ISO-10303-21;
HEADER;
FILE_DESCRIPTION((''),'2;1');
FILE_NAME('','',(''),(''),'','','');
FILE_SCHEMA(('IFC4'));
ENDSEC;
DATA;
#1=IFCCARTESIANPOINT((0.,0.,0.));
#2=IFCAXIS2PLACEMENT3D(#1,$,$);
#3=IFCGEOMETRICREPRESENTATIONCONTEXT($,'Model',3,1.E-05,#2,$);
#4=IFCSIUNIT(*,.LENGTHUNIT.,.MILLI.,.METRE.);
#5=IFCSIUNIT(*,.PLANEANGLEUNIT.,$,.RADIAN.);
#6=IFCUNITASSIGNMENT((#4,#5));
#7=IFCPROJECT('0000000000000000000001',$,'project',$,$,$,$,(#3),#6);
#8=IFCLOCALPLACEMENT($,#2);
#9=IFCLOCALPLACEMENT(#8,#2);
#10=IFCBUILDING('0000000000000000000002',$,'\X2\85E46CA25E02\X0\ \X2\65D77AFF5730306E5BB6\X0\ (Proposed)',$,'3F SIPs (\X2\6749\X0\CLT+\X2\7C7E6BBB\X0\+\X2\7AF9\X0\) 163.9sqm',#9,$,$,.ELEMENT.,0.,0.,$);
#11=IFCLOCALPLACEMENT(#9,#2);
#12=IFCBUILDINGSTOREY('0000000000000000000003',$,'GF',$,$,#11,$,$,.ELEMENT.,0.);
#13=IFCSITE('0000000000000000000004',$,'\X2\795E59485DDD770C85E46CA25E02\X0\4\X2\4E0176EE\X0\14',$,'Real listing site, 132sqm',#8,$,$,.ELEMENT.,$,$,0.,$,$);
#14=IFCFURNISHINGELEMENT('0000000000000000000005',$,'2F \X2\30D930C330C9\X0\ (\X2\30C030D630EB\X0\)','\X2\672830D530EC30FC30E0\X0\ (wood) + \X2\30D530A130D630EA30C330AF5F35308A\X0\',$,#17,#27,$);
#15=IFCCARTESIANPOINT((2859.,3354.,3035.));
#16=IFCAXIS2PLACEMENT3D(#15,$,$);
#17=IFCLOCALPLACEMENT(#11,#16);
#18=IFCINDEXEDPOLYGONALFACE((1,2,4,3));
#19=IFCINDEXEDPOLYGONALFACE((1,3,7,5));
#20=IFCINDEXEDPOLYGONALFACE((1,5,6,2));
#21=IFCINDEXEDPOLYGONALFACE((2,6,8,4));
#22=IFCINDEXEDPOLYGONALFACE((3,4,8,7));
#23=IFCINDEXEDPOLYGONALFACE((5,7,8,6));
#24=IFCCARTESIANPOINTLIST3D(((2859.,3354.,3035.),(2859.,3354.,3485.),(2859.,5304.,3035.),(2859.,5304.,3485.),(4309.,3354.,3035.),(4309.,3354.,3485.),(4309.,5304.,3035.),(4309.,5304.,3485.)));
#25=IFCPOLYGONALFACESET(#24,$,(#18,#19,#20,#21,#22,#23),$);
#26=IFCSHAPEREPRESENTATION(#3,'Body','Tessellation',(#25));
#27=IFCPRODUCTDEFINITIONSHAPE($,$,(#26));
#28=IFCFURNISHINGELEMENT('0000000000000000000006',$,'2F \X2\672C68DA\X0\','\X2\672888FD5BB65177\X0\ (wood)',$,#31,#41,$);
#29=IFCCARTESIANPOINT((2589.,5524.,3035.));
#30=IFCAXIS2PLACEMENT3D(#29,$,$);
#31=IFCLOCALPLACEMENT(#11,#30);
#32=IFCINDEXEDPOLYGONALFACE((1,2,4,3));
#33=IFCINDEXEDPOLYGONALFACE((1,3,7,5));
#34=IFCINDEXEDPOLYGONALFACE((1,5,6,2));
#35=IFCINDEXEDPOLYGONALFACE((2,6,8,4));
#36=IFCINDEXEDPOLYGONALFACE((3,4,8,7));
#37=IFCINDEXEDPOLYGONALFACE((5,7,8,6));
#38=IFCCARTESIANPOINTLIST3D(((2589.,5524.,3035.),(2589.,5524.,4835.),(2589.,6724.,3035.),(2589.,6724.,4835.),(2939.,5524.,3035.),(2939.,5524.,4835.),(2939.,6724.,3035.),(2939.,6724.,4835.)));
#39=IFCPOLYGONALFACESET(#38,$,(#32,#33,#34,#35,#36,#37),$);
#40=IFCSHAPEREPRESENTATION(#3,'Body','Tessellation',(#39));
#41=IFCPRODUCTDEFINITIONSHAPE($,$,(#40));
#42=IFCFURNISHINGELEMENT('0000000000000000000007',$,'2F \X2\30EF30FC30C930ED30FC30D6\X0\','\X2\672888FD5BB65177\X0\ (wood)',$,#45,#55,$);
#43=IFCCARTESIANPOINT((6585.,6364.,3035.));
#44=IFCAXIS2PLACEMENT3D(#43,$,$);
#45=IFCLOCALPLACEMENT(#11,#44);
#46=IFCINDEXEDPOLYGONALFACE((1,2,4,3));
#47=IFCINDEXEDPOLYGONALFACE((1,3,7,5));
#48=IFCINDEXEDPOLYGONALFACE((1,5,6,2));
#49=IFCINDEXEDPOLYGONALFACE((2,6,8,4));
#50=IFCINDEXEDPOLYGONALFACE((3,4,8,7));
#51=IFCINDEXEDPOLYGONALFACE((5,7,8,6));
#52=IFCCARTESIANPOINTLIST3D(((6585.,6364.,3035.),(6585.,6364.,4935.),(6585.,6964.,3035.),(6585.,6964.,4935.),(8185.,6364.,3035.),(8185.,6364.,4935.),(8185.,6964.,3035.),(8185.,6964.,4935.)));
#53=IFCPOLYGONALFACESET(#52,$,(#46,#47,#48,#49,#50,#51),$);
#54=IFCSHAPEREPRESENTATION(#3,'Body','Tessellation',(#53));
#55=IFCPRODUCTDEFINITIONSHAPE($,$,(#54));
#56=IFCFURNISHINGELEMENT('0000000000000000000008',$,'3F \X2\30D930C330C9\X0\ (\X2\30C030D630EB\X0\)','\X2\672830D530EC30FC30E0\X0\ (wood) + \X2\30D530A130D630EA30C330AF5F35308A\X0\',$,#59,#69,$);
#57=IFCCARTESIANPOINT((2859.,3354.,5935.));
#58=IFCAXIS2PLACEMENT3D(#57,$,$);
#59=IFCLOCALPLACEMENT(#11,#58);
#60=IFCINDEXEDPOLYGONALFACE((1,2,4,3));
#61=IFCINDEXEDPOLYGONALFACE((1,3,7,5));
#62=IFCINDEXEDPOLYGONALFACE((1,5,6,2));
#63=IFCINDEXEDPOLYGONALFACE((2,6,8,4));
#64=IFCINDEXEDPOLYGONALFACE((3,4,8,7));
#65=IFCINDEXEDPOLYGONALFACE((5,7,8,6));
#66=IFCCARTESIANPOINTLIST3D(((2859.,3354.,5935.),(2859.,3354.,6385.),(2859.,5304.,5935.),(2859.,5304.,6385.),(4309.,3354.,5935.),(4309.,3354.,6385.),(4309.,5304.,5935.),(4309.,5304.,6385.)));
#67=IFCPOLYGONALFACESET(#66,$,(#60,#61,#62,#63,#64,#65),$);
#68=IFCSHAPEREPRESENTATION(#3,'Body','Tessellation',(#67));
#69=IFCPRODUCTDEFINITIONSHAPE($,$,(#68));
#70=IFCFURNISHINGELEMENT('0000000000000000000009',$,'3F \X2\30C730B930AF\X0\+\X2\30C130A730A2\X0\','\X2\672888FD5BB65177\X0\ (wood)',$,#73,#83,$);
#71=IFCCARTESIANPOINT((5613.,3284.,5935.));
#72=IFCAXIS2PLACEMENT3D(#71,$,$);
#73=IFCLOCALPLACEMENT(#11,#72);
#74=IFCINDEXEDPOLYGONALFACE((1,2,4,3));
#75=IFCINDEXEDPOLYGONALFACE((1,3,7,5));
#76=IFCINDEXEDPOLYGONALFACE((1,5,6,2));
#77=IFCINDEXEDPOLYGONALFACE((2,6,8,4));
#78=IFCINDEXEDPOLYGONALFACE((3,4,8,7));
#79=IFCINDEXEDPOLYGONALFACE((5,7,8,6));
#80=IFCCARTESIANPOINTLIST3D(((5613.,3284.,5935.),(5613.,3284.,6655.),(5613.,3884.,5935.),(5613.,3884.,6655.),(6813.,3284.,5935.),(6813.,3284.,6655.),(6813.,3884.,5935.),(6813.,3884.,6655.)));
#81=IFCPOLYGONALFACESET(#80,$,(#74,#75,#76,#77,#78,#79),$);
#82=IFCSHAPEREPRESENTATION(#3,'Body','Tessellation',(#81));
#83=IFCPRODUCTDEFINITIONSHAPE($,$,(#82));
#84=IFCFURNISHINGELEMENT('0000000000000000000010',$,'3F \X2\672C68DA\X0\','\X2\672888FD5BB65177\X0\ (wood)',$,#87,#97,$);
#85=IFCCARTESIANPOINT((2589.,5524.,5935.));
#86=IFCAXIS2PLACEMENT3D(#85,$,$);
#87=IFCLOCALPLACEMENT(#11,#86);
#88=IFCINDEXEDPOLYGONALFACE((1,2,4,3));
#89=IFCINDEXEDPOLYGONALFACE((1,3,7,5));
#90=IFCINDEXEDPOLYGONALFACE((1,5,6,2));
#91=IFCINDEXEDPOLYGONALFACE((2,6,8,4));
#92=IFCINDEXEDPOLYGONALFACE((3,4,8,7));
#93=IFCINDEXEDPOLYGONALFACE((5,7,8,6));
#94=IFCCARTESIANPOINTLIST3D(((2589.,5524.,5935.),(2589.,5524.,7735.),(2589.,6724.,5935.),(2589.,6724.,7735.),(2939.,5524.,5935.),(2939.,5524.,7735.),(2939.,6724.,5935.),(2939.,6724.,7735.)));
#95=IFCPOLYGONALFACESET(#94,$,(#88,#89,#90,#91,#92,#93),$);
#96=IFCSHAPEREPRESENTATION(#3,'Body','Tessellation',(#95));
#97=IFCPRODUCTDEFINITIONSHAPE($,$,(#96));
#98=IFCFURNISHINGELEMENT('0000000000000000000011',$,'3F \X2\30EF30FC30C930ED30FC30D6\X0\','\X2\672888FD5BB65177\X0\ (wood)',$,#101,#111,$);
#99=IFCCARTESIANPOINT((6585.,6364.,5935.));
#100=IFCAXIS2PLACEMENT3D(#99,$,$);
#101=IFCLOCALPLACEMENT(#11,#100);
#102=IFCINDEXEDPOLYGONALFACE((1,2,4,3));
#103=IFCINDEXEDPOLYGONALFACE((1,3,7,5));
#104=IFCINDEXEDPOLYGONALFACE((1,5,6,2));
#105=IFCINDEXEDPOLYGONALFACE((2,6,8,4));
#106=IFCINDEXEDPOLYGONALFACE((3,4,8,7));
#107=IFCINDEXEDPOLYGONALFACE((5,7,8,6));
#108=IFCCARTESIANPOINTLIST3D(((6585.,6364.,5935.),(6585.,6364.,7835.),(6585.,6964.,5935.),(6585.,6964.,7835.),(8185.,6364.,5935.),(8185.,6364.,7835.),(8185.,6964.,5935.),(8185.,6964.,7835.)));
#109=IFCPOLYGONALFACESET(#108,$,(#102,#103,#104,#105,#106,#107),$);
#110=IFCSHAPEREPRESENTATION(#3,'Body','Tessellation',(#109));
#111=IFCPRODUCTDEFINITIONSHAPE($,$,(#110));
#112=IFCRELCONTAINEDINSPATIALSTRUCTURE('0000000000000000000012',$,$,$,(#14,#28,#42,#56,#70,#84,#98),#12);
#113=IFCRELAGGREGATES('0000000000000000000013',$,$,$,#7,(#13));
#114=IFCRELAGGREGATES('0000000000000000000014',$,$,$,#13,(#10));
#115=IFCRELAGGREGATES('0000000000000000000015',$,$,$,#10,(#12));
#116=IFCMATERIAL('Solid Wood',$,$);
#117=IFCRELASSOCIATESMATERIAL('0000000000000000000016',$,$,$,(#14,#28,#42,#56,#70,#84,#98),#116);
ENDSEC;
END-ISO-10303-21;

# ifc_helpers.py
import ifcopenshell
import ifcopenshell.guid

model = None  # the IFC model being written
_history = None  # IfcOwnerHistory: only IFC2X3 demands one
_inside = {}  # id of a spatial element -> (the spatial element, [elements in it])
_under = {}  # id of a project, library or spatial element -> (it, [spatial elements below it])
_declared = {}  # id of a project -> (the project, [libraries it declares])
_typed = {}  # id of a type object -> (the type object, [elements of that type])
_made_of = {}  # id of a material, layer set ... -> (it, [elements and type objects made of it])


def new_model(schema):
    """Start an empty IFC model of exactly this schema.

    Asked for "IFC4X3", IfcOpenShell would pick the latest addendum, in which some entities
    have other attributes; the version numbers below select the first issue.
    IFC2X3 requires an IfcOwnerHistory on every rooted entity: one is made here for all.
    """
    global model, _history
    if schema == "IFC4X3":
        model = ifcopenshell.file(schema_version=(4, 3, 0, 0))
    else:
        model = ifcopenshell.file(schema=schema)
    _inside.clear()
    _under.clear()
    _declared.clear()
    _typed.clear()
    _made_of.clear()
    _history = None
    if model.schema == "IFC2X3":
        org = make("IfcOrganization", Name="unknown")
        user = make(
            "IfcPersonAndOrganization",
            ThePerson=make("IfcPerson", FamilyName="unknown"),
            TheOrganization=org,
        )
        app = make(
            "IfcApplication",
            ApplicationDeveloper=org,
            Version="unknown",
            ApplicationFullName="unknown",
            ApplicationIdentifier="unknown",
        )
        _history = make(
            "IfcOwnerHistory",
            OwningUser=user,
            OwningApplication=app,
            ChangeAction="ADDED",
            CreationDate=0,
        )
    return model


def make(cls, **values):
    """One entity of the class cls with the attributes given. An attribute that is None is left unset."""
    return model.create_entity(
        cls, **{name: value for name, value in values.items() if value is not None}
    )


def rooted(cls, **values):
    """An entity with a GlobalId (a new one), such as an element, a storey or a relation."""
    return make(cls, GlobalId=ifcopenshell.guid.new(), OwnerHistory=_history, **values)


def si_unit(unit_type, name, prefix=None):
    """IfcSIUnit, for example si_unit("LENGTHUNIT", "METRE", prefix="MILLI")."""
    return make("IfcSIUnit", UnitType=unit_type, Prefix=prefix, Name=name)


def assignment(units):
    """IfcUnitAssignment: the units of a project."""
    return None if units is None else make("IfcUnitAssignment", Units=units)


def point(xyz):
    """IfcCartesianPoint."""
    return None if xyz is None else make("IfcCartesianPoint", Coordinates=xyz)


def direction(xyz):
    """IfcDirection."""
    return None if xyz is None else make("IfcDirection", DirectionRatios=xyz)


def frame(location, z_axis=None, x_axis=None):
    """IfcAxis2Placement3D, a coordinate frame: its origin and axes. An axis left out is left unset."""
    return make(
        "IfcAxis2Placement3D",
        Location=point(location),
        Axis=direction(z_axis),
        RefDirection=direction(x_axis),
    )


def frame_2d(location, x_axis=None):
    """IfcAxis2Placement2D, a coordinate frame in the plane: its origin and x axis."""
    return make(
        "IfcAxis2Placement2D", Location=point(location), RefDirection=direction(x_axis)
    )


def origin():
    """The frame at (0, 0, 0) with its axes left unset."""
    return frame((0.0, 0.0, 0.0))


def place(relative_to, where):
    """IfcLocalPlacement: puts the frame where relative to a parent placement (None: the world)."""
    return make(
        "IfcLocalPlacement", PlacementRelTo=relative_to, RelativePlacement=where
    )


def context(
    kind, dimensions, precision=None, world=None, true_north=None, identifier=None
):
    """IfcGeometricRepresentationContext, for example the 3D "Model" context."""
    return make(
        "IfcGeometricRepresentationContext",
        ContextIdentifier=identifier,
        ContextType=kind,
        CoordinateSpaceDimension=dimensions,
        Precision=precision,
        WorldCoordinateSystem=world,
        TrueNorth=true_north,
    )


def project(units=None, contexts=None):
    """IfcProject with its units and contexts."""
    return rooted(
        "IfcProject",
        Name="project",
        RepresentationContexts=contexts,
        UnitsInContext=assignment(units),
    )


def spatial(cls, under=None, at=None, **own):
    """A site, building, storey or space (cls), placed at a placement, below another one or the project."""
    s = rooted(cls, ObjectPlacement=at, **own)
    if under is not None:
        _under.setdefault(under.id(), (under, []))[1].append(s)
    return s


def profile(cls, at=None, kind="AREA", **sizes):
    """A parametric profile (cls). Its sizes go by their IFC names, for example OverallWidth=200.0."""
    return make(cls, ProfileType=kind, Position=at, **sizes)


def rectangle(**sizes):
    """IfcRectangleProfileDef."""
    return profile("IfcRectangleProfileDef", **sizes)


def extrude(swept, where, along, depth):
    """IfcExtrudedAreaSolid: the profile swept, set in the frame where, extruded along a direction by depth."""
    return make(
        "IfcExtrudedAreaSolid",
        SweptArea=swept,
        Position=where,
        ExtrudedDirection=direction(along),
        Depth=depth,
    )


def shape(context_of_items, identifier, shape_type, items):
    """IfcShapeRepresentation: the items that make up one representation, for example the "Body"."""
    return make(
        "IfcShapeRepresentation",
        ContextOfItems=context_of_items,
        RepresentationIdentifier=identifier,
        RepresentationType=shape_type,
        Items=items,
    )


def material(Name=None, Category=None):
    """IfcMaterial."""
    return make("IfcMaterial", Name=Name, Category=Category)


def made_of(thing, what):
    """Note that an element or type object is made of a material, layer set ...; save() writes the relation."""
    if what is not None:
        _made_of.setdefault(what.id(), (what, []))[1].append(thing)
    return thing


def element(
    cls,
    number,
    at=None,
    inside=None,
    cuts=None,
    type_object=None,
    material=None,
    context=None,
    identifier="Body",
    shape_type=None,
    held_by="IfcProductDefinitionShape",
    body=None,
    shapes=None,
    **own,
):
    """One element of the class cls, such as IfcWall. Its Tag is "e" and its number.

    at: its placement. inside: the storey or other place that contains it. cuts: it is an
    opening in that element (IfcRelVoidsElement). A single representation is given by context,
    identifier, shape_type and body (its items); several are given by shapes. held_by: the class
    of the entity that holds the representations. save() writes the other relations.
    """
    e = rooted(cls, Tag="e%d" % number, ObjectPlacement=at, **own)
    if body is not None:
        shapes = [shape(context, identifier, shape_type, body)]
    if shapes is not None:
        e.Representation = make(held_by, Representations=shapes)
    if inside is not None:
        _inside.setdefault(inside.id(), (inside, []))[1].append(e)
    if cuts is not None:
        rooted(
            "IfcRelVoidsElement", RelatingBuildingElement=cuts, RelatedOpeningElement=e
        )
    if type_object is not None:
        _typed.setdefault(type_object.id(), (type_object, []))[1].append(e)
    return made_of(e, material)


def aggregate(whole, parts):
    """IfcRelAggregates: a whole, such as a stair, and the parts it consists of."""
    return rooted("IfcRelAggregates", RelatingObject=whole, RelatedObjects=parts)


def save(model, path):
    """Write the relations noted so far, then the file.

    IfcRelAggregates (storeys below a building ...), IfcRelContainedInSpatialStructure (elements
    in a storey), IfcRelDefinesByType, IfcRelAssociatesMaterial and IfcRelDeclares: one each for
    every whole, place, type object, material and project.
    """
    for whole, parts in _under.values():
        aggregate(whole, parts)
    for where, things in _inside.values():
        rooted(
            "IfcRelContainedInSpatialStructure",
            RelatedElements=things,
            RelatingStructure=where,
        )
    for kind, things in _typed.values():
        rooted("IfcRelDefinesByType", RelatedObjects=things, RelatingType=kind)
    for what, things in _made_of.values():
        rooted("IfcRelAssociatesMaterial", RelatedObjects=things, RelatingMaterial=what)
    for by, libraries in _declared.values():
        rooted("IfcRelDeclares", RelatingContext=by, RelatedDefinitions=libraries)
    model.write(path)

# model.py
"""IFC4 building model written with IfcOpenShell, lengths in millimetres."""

from ifc_helpers import new_model, si_unit, frame, frame_2d, origin, place, context, project, spatial, rectangle, extrude, material, element, save


model = new_model("IFC4")

# Units and contexts
model_context = context("Model", 3, precision=1e-05, world=origin())
ifc_project = project(units=[si_unit("LENGTHUNIT", "METRE", prefix="MILLI"), si_unit("PLANEANGLEUNIT", "RADIAN")], contexts=[model_context])

# Site, building, storey
site_placement = place(None, origin())
site = spatial("IfcSite", under=ifc_project, at=site_placement, Name="神奈川県藤沢市4丁目14", ObjectType="Real listing site, 132sqm", CompositionType="ELEMENT", RefElevation=0.0)
building_placement = place(site_placement, origin())
building = spatial("IfcBuilding", under=site, at=building_placement, Name="藤沢市 旗竿地の家 (Proposed)", ObjectType="3F SIPs (杉CLT+籾殻+竹) 163.9sqm", CompositionType="ELEMENT", ElevationOfRefHeight=0.0, ElevationOfTerrain=0.0)
storey_placement = place(building_placement, origin())
storey = spatial("IfcBuildingStorey", under=building, at=storey_placement, Name="GF", CompositionType="ELEMENT", Elevation=0.0)

# Shared definitions
ifc_material_1 = material(Name="Solid Wood")

# Furnishing elements
furnishing_1_placement = place(storey_placement, frame((2859.0, 3354.0, 3035.0)))
element("IfcFurnishingElement", 1, at=furnishing_1_placement, inside=storey, material=ifc_material_1, Name="2F ベッド (ダブル)", Description="木フレーム (wood) + ファブリック張り", context=model_context, shape_type="SweptSolid", body=[
    extrude(rectangle(XDim=1450.0, YDim=1950.0, at=frame_2d((725.0, 975.0))), frame((2859.0, 3354.0, 3035.0)), (0.0, 0.0, 1.0), 450.0),
])
furnishing_2_placement = place(storey_placement, frame((2589.0, 5524.0, 3035.0)))
element("IfcFurnishingElement", 2, at=furnishing_2_placement, inside=storey, material=ifc_material_1, Name="2F 本棚", Description="木製家具 (wood)", context=model_context, shape_type="SweptSolid", body=[
    extrude(rectangle(XDim=350.0, YDim=1200.0, at=frame_2d((175.0, 600.0))), frame((2589.0, 5524.0, 3035.0)), (0.0, 0.0, 1.0), 1800.0),
])
furnishing_3_placement = place(storey_placement, frame((6585.0, 6364.0, 3035.0)))
element("IfcFurnishingElement", 3, at=furnishing_3_placement, inside=storey, material=ifc_material_1, Name="2F ワードローブ", Description="木製家具 (wood)", context=model_context, shape_type="SweptSolid", body=[
    extrude(rectangle(XDim=1600.0, YDim=600.0, at=frame_2d((800.0, 300.0))), frame((6585.0, 6364.0, 3035.0)), (0.0, 0.0, 1.0), 1900.0),
])
furnishing_4_placement = place(storey_placement, frame((2859.0, 3354.0, 5935.0)))
element("IfcFurnishingElement", 4, at=furnishing_4_placement, inside=storey, material=ifc_material_1, Name="3F ベッド (ダブル)", Description="木フレーム (wood) + ファブリック張り", context=model_context, shape_type="SweptSolid", body=[
    extrude(rectangle(XDim=1450.0, YDim=1950.0, at=frame_2d((725.0, 975.0))), frame((2859.0, 3354.0, 5935.0)), (0.0, 0.0, 1.0), 450.0),
])
furnishing_5_placement = place(storey_placement, frame((5613.0, 3284.0, 5935.0)))
element("IfcFurnishingElement", 5, at=furnishing_5_placement, inside=storey, material=ifc_material_1, Name="3F デスク+チェア", Description="木製家具 (wood)", context=model_context, shape_type="SweptSolid", body=[
    extrude(rectangle(XDim=1200.0, YDim=600.0, at=frame_2d((600.0, 300.0))), frame((5613.0, 3284.0, 5935.0)), (0.0, 0.0, 1.0), 720.0),
])
furnishing_6_placement = place(storey_placement, frame((2589.0, 5524.0, 5935.0)))
element("IfcFurnishingElement", 6, at=furnishing_6_placement, inside=storey, material=ifc_material_1, Name="3F 本棚", Description="木製家具 (wood)", context=model_context, shape_type="SweptSolid", body=[
    extrude(rectangle(XDim=350.0, YDim=1200.0, at=frame_2d((175.0, 600.0))), frame((2589.0, 5524.0, 5935.0)), (0.0, 0.0, 1.0), 1800.0),
])
furnishing_7_placement = place(storey_placement, frame((6585.0, 6364.0, 5935.0)))
element("IfcFurnishingElement", 7, at=furnishing_7_placement, inside=storey, material=ifc_material_1, Name="3F ワードローブ", Description="木製家具 (wood)", context=model_context, shape_type="SweptSolid", body=[
    extrude(rectangle(XDim=1600.0, YDim=600.0, at=frame_2d((800.0, 300.0))), frame((6585.0, 6364.0, 5935.0)), (0.0, 0.0, 1.0), 1900.0),
])

save(model, "model.ifc")
